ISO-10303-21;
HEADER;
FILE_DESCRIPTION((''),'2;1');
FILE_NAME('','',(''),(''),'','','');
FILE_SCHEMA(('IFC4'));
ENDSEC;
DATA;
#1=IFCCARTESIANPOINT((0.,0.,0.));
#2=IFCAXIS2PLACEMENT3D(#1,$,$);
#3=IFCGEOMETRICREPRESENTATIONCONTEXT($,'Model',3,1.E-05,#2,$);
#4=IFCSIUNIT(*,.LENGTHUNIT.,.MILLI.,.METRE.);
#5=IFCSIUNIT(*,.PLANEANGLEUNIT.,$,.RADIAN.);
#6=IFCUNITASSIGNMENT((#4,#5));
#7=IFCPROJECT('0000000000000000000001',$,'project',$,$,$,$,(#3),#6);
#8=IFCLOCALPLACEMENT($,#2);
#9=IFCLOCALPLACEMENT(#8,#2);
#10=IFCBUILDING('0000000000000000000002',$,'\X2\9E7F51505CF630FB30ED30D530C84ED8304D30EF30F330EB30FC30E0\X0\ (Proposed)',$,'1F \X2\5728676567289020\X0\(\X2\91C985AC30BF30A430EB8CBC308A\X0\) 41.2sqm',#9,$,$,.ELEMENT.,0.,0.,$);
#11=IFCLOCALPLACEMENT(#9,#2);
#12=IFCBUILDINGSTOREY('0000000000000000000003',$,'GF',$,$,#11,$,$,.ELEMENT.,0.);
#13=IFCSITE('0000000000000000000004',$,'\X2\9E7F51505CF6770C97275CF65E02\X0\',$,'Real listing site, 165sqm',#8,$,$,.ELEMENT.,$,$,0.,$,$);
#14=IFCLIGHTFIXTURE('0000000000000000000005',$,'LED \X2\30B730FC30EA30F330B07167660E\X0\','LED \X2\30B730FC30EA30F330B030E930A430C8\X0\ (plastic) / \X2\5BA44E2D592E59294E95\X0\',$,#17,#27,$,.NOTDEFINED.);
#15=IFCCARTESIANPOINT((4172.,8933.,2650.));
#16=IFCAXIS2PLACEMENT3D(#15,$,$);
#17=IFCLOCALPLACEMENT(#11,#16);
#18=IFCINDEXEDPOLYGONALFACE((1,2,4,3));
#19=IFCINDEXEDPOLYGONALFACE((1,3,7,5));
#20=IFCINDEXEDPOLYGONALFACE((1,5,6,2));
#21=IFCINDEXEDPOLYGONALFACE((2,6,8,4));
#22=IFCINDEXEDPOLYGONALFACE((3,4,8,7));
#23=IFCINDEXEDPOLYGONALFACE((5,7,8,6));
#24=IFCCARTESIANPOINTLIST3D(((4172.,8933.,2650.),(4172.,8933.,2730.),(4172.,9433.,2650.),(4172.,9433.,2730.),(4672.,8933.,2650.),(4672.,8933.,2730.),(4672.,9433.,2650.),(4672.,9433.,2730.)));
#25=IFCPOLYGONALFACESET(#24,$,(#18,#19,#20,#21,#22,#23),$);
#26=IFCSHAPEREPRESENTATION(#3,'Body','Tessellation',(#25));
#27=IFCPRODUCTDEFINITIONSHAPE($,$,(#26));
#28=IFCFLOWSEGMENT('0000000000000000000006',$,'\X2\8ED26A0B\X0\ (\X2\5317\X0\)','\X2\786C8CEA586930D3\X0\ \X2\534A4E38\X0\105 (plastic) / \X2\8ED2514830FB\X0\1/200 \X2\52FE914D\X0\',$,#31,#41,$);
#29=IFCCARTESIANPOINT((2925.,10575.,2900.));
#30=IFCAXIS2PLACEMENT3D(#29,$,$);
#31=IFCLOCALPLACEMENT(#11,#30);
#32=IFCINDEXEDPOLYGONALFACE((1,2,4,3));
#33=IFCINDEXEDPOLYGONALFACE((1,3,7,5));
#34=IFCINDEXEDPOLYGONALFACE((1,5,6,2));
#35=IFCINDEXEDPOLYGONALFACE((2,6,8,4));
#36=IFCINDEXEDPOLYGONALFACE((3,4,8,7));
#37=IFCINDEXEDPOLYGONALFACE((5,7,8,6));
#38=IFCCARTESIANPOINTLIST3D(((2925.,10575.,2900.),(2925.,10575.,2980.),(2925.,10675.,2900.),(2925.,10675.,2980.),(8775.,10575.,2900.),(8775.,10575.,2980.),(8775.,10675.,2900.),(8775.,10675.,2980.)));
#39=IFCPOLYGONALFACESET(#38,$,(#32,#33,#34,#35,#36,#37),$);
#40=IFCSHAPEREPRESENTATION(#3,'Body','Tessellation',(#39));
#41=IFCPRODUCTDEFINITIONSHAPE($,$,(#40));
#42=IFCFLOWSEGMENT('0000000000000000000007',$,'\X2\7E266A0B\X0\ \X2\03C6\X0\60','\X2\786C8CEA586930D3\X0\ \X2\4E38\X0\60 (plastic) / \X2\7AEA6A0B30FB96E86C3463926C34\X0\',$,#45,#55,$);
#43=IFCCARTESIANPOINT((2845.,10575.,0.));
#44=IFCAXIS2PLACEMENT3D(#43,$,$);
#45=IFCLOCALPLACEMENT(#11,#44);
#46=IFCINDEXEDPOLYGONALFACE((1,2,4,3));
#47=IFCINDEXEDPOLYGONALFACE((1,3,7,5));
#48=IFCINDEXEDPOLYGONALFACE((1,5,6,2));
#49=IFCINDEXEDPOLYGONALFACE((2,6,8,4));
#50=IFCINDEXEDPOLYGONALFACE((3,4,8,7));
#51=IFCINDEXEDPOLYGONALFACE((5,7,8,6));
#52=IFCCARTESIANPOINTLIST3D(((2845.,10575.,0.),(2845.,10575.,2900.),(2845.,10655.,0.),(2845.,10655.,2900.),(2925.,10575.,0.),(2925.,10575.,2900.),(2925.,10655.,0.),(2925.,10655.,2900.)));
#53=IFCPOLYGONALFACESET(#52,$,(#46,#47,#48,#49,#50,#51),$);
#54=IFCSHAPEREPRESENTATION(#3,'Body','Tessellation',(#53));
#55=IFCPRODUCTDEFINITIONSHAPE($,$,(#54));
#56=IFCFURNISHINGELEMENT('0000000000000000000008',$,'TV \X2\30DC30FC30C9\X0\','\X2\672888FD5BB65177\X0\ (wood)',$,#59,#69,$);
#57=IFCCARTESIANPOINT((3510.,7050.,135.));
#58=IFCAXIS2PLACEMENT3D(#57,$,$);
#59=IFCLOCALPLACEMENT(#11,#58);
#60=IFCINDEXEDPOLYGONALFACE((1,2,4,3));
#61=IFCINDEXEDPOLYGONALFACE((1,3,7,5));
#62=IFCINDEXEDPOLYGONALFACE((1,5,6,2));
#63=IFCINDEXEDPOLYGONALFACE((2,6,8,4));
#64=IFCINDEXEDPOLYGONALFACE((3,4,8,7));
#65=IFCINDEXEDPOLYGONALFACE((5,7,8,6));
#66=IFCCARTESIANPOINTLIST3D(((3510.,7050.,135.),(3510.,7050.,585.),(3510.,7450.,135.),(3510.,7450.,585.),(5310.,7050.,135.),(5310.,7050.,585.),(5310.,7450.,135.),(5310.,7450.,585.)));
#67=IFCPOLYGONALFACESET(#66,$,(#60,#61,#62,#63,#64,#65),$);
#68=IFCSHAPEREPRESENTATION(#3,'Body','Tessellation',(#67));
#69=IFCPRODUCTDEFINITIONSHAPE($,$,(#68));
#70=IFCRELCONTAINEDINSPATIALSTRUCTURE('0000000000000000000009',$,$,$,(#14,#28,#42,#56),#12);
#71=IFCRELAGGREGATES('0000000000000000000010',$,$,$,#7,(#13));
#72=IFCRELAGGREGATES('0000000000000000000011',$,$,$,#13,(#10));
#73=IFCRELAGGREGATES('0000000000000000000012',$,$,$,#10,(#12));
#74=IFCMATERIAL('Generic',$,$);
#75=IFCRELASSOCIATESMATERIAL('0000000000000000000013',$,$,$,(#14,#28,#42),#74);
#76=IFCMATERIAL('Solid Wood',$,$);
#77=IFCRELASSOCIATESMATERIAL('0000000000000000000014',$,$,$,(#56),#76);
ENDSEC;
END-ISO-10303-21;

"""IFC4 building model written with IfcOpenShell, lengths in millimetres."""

from ifc_helpers import new_model, si_unit, frame, frame_2d, origin, place, context, project, spatial, rectangle, extrude, material, element, save


model = new_model("IFC4")

# Units and contexts
model_context = context("Model", 3, precision=1e-05, world=origin())
ifc_project = project(units=[si_unit("LENGTHUNIT", "METRE", prefix="MILLI"), si_unit("PLANEANGLEUNIT", "RADIAN")], contexts=[model_context])

# Site, building, storey
site_placement = place(None, origin())
site = spatial("IfcSite", under=ifc_project, at=site_placement, Name="鹿児島県霧島市", ObjectType="Real listing site, 165sqm", CompositionType="ELEMENT", RefElevation=0.0)
building_placement = place(site_placement, origin())
building = spatial("IfcBuilding", under=site, at=building_placement, Name="鹿児島・ロフト付きワンルーム (Proposed)", ObjectType="1F 在来木造(釉薬タイル貼り) 41.2sqm", CompositionType="ELEMENT", ElevationOfRefHeight=0.0, ElevationOfTerrain=0.0)
storey_placement = place(building_placement, origin())
storey = spatial("IfcBuildingStorey", under=building, at=storey_placement, Name="GF", CompositionType="ELEMENT", Elevation=0.0)

# Shared definitions
ifc_material_1 = material(Name="Solid Wood")

# Shared definitions
ifc_material_2 = material(Name="Generic")

# Light fixture
light_fixture_placement = place(storey_placement, frame((4172.0, 8933.0, 2650.0)))
element("IfcLightFixture", 1, at=light_fixture_placement, inside=storey, material=ifc_material_2, Name="LED シーリング照明", Description="LED シーリングライト (plastic) / 室中央天井", PredefinedType="NOTDEFINED", context=model_context, shape_type="SweptSolid", body=[
    extrude(rectangle(XDim=500.0, YDim=500.0, at=frame_2d((250.0, 250.0))), frame((4172.0, 8933.0, 2650.0)), (0.0, 0.0, 1.0), 80.0),
])

# Flow segments
flow_segment_1_placement = place(storey_placement, frame((2925.0, 10575.0, 2900.0)))
element("IfcFlowSegment", 2, at=flow_segment_1_placement, inside=storey, material=ifc_material_2, Name="軒樋 (北)", Description="硬質塩ビ 半丸105 (plastic) / 軒先・1/200 勾配", context=model_context, shape_type="SweptSolid", body=[
    extrude(rectangle(XDim=5850.0, YDim=100.0, at=frame_2d((2925.0, 50.0))), frame((2925.0, 10575.0, 2900.0)), (0.0, 0.0, 1.0), 80.0),
])
flow_segment_2_placement = place(storey_placement, frame((2845.0, 10575.0, 0.0)))
element("IfcFlowSegment", 3, at=flow_segment_2_placement, inside=storey, material=ifc_material_2, Name="縦樋 φ60", Description="硬質塩ビ 丸60 (plastic) / 竪樋・雨水排水", context=model_context, shape_type="SweptSolid", body=[
    extrude(rectangle(XDim=80.0, YDim=80.0, at=frame_2d((40.0, 40.0))), frame((2845.0, 10575.0, 0.0)), (0.0, 0.0, 1.0), 2900.0),
])

# Furnishing element
furnishing_placement = place(storey_placement, frame((3510.0, 7050.0, 135.0)))
element("IfcFurnishingElement", 4, at=furnishing_placement, inside=storey, material=ifc_material_1, Name="TV ボード", Description="木製家具 (wood)", context=model_context, shape_type="SweptSolid", body=[
    extrude(rectangle(XDim=1800.0, YDim=400.0, at=frame_2d((900.0, 200.0))), frame((3510.0, 7050.0, 135.0)), (0.0, 0.0, 1.0), 450.0),
])

save(model, "model.ifc")
